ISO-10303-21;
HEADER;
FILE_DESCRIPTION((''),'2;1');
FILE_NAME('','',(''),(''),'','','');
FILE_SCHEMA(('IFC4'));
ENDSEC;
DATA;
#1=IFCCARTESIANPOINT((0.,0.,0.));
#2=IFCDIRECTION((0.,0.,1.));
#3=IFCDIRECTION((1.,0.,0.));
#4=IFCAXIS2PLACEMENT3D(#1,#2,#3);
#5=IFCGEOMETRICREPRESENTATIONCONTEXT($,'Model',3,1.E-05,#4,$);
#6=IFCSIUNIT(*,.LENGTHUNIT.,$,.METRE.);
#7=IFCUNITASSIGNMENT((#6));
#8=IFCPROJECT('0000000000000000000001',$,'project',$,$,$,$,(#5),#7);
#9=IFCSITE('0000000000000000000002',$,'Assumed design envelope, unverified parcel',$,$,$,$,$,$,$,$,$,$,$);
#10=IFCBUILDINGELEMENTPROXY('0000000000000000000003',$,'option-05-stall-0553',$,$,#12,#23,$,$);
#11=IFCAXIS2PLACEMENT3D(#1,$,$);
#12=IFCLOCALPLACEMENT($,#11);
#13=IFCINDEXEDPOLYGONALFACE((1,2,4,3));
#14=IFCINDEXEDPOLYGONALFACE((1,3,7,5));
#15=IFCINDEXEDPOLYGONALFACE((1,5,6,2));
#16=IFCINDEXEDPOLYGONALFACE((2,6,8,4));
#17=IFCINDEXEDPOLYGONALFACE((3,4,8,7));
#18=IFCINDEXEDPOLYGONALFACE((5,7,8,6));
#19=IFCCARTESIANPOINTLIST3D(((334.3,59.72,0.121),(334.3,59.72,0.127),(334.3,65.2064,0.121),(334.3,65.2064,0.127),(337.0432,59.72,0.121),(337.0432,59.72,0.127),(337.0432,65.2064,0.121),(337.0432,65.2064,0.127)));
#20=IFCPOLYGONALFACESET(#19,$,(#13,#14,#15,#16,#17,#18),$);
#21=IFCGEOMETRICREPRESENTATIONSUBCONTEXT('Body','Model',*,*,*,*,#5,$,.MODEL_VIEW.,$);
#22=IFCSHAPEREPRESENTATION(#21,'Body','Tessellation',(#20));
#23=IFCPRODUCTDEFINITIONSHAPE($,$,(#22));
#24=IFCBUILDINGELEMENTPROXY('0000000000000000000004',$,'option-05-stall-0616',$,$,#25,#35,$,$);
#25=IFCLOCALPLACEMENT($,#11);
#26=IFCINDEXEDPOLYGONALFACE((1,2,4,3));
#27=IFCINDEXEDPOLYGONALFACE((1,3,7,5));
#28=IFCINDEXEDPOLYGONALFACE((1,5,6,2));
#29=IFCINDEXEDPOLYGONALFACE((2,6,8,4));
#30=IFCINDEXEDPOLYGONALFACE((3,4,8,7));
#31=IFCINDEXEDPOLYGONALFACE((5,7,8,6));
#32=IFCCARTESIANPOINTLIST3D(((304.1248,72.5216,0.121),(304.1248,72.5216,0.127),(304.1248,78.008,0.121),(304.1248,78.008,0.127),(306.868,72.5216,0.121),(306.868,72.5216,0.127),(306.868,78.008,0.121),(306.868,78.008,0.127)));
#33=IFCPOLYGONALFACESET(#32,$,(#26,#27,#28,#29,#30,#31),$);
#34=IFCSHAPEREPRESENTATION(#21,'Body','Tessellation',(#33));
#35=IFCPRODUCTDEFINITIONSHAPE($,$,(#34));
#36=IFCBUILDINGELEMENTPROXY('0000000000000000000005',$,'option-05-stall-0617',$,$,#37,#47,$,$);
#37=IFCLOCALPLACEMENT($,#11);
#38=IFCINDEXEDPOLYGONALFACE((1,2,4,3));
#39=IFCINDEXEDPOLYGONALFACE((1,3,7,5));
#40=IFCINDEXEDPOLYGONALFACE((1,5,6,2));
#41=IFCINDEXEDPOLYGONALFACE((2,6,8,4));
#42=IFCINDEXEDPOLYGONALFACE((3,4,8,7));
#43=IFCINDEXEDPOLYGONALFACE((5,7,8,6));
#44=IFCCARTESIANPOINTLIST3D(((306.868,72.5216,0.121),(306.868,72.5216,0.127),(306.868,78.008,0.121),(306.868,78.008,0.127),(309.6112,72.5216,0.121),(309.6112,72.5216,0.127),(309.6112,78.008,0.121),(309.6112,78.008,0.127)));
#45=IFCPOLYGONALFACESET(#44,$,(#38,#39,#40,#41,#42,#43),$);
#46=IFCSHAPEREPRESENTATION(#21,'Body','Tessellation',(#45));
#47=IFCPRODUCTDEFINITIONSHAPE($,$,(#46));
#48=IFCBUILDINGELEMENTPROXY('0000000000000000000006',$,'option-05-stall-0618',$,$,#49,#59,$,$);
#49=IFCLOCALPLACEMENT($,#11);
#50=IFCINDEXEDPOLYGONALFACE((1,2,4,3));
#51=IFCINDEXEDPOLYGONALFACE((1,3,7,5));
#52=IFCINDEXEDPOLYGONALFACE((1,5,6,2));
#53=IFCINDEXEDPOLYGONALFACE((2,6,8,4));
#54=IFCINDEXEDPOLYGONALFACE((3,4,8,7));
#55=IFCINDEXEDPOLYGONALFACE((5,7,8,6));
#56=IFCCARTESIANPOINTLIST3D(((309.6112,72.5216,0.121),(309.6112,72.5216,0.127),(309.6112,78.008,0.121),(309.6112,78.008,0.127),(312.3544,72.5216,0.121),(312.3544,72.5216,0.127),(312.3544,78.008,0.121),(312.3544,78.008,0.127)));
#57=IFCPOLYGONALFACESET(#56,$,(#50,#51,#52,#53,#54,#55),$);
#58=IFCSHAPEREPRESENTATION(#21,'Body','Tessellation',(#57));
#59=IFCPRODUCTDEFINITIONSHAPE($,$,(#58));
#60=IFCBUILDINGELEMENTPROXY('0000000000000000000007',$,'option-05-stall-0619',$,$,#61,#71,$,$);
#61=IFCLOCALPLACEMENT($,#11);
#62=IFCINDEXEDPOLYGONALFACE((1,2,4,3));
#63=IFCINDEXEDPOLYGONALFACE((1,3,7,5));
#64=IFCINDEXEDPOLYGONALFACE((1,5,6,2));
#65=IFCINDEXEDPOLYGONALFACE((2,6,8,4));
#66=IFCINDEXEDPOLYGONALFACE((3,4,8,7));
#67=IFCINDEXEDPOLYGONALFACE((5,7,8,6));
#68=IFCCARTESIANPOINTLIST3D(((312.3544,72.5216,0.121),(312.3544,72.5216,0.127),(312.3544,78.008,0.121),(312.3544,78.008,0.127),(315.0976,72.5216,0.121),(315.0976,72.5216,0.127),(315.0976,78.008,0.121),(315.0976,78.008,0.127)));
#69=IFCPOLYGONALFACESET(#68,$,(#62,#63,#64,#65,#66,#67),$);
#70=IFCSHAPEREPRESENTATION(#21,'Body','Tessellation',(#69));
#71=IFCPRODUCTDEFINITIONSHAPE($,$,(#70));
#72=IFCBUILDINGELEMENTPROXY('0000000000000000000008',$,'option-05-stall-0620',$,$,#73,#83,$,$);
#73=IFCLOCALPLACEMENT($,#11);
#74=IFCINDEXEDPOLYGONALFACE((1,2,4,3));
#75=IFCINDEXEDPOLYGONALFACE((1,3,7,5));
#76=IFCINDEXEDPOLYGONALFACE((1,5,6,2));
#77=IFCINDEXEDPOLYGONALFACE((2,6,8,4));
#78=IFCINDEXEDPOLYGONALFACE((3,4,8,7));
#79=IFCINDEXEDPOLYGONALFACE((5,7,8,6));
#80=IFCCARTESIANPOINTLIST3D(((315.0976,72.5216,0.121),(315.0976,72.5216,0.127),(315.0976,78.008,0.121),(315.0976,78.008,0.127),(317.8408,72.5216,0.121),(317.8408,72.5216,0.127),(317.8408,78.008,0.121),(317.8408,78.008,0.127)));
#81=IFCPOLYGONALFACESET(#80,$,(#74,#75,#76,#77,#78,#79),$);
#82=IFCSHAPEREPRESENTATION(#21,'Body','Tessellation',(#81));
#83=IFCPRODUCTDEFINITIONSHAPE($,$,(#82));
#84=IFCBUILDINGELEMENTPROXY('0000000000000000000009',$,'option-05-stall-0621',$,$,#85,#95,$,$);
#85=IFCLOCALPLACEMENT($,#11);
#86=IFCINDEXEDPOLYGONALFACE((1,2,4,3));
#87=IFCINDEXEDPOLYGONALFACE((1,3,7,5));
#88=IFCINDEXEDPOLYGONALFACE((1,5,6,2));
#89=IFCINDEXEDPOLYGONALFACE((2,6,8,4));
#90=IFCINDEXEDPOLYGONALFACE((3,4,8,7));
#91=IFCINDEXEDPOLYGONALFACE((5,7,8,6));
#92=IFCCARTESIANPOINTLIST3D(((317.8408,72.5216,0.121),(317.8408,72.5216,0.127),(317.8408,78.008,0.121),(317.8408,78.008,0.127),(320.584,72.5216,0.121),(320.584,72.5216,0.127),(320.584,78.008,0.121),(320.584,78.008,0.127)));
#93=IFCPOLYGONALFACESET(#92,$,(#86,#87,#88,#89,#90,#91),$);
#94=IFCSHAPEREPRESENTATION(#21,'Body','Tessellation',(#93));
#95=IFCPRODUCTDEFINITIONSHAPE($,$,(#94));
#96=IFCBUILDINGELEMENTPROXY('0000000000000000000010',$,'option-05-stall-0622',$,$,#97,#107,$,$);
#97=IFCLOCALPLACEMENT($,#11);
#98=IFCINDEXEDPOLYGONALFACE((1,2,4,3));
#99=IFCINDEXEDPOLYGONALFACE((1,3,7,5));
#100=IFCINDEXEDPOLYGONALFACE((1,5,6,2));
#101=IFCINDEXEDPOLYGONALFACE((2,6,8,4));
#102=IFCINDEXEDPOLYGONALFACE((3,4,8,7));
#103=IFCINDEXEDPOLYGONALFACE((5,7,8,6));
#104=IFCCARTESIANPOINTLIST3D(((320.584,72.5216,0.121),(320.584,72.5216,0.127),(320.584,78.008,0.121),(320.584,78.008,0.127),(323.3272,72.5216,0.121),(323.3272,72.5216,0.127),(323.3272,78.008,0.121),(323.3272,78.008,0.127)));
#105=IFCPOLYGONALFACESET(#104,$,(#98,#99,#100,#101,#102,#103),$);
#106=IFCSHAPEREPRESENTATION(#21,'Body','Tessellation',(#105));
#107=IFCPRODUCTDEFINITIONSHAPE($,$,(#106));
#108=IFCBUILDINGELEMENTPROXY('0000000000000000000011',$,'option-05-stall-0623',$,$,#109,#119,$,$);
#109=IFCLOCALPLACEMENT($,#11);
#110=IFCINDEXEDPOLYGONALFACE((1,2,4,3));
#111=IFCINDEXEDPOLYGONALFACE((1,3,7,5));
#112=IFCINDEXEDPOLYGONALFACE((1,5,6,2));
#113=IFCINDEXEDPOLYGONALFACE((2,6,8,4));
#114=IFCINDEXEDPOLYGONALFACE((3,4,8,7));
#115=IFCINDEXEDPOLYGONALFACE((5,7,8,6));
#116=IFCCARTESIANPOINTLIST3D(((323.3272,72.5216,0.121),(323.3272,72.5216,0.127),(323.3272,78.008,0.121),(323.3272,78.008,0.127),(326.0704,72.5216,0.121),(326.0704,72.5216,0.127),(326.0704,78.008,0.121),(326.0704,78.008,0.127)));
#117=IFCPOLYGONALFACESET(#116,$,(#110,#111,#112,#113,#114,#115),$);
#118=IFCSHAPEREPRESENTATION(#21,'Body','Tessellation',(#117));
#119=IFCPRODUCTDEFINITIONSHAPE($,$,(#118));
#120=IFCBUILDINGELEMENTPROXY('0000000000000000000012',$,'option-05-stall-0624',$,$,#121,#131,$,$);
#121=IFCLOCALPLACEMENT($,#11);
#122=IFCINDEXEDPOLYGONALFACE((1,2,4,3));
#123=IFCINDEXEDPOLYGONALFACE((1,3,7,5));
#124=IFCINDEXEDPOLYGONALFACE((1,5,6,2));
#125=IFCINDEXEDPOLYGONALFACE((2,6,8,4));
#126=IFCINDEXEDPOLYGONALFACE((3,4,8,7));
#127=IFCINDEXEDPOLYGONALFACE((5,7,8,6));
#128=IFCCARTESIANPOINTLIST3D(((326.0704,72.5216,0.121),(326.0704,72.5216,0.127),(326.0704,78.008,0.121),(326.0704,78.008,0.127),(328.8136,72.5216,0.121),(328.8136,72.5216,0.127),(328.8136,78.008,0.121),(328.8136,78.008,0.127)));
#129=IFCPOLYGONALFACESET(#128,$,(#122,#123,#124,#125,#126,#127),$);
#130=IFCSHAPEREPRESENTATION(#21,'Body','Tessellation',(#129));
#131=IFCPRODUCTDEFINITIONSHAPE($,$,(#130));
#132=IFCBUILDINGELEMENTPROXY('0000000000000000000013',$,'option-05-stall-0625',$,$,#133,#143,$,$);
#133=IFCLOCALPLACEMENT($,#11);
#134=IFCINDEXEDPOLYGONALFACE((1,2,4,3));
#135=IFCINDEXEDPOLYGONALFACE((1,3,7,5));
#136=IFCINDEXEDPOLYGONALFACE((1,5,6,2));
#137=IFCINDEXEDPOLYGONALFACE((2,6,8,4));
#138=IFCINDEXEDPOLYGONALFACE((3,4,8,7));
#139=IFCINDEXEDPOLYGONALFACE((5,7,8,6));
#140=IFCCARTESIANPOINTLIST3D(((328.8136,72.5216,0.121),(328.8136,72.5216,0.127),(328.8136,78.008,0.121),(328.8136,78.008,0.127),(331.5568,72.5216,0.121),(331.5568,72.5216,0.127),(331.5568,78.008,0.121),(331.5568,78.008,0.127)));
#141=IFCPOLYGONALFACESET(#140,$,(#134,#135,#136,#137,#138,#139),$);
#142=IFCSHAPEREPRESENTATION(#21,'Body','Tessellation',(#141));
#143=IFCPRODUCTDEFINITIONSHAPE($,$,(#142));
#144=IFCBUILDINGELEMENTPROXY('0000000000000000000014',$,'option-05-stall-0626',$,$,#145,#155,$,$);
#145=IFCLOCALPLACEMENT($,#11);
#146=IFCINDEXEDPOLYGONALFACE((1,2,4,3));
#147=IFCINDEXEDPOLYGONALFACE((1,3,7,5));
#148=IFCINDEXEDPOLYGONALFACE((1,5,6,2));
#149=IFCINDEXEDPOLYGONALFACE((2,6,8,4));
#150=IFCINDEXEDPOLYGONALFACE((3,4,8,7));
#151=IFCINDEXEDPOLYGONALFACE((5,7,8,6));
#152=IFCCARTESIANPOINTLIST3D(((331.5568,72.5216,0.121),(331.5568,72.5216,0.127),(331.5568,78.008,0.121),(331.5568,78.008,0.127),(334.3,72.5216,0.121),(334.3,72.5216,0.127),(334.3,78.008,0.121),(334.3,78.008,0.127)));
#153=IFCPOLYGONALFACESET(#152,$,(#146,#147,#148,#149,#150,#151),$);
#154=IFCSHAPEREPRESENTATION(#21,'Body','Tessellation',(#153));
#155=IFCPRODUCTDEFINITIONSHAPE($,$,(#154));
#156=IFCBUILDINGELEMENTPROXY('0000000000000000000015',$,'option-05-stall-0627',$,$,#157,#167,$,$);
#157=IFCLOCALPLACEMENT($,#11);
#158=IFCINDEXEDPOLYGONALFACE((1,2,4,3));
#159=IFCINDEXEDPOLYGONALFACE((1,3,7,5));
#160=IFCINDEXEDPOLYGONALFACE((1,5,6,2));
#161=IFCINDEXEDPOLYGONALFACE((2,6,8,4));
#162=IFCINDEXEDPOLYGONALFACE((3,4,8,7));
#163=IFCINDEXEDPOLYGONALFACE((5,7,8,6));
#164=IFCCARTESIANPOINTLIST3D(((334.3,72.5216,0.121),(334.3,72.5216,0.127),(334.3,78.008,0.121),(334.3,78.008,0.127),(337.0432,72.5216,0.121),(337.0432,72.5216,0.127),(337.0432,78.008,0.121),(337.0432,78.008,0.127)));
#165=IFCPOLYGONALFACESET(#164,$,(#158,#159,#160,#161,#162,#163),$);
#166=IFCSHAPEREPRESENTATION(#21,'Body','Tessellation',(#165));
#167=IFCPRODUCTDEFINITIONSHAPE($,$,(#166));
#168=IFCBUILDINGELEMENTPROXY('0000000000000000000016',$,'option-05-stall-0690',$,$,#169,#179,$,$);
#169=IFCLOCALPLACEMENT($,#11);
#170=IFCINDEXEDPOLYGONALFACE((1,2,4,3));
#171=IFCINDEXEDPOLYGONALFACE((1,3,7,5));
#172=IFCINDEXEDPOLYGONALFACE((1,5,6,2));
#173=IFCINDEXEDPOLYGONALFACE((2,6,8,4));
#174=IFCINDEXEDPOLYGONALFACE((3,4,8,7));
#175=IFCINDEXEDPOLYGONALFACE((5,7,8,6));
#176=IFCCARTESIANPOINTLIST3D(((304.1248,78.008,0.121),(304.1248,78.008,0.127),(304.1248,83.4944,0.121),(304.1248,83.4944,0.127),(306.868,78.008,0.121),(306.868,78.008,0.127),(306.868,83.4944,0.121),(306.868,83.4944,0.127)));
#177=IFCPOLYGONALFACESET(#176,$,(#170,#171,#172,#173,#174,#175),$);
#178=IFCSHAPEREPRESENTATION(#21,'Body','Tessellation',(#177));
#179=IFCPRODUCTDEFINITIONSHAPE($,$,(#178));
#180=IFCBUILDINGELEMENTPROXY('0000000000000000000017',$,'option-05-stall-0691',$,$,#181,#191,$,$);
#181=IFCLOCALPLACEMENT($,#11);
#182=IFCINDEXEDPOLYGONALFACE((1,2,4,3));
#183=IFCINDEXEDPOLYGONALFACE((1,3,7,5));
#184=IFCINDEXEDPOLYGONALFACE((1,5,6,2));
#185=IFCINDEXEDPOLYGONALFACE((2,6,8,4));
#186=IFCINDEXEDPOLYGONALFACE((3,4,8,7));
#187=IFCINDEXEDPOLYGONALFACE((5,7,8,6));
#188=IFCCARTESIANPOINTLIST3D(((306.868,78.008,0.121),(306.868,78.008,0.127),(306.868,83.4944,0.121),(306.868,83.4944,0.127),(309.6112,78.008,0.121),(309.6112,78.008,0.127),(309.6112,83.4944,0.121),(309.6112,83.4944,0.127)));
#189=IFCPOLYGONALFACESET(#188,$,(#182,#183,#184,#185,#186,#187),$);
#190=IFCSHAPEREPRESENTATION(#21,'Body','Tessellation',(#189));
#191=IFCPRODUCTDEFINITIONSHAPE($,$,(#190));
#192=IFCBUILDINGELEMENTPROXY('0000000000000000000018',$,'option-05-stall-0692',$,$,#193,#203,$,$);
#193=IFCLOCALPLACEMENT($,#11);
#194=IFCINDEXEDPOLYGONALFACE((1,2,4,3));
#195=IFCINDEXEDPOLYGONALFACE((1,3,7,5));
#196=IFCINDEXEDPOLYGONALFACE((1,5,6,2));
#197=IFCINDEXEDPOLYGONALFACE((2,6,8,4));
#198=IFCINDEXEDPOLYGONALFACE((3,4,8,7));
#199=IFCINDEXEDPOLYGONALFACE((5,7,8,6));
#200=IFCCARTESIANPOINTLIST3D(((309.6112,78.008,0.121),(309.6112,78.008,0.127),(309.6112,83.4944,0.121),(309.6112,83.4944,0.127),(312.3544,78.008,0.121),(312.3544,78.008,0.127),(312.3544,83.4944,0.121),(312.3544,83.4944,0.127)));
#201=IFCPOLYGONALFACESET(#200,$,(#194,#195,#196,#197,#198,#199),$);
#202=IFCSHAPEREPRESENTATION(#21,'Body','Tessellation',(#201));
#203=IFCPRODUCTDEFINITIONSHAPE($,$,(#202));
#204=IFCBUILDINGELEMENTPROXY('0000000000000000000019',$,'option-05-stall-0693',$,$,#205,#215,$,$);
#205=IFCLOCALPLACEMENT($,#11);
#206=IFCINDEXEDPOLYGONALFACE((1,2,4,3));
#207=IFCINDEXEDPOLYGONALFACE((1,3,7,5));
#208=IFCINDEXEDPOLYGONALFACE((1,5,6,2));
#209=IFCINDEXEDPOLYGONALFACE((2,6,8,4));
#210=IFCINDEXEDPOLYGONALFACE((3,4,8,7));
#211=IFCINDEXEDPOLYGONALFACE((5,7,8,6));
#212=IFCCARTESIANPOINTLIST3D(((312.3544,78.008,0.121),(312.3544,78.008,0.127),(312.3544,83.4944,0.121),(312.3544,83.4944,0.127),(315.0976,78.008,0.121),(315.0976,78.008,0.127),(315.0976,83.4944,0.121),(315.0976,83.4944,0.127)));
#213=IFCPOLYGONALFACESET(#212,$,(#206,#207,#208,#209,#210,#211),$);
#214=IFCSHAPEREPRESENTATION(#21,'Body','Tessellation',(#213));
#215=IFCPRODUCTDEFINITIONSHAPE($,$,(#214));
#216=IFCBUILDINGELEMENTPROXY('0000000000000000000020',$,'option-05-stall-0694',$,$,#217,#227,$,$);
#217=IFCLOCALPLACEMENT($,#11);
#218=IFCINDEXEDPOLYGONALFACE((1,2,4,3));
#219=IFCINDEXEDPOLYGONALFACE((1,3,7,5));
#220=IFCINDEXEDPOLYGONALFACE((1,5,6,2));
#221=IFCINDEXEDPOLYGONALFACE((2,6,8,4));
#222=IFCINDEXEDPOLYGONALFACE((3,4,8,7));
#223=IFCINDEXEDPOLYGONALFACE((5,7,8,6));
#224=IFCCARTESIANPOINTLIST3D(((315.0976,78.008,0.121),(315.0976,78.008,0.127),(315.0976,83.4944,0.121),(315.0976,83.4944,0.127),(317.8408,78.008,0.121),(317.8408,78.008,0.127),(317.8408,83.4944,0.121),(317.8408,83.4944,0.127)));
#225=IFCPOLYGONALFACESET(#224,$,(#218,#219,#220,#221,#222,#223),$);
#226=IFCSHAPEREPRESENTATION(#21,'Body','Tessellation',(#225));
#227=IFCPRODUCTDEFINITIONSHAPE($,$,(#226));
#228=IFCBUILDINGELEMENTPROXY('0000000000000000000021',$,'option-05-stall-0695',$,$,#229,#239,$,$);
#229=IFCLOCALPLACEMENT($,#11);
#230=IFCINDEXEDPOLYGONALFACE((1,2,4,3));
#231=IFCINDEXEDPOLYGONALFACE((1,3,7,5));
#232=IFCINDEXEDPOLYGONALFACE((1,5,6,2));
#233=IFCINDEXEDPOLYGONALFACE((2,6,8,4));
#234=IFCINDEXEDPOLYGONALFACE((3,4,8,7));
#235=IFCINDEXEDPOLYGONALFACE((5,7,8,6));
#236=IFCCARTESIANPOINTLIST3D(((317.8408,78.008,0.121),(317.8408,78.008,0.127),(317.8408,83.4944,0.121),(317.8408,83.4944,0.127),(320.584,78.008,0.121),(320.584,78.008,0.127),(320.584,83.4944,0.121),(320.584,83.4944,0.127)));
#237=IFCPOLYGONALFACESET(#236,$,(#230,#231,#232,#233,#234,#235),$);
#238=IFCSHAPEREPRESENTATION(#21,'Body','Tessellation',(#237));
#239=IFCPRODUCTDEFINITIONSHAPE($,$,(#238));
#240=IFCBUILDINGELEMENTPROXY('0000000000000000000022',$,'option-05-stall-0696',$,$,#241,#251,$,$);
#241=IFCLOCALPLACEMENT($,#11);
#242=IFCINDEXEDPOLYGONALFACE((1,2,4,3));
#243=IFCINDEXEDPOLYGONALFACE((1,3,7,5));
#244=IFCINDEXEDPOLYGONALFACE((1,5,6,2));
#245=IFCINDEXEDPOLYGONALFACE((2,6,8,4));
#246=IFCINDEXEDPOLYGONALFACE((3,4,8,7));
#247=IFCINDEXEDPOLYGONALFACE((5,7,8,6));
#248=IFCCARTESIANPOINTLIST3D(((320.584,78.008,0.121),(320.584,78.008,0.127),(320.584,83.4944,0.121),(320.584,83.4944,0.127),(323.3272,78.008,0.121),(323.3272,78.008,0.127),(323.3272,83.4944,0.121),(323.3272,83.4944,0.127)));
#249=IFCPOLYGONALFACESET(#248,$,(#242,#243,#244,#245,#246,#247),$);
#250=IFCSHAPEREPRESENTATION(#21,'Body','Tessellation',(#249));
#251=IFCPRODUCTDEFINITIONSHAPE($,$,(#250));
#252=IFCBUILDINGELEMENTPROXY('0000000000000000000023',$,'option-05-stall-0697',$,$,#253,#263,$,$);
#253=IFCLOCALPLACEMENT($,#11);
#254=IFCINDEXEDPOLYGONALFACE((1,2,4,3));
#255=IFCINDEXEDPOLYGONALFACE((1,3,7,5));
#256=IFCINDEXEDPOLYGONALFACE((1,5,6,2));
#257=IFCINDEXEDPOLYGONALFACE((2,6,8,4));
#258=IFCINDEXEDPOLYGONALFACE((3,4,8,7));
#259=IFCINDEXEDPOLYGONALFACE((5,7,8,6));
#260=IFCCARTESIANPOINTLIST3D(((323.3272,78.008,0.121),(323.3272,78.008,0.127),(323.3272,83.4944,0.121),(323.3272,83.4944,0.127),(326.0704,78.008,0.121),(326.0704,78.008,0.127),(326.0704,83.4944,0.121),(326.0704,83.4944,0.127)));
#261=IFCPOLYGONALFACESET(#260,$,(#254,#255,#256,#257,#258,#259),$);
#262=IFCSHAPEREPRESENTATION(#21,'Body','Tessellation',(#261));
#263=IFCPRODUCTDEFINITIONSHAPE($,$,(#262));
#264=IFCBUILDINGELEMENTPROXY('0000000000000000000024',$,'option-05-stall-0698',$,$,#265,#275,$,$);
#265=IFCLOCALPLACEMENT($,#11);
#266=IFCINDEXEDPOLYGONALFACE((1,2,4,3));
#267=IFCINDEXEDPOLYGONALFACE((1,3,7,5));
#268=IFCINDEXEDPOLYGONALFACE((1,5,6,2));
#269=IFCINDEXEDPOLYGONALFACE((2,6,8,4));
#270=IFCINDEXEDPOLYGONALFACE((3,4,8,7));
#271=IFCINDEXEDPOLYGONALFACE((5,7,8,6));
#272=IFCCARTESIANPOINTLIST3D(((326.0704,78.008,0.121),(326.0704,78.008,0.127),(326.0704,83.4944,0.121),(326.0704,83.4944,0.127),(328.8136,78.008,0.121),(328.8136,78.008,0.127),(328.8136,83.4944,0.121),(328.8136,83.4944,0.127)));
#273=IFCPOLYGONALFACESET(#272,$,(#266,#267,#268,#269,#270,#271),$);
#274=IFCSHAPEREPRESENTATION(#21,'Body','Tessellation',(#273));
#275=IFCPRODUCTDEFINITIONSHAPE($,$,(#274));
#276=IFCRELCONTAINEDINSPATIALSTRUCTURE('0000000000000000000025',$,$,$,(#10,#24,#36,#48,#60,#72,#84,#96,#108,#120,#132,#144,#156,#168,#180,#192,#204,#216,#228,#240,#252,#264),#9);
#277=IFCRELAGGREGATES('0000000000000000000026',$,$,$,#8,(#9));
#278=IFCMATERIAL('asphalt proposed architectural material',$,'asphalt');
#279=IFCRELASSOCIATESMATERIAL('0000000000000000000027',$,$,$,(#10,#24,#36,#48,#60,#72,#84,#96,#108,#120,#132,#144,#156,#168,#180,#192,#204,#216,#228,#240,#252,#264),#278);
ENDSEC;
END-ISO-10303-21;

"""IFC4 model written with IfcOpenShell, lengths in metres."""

from ifc_helpers import new_model, si_unit, frame, origin_with_axes, place, context, subcontext, project, spatial, rectangle, extrude, material, element, save


model = new_model("IFC4")

# Units and contexts
model_context = context("Model", 3, precision=1e-05, world=origin_with_axes())
body_context = subcontext(model_context, "Body", "Model", "MODEL_VIEW")
ifc_project = project(units=[si_unit("LENGTHUNIT", "METRE")], contexts=[model_context])

# Site
site = spatial("IfcSite", under=ifc_project, Name="Assumed design envelope, unverified parcel")

# Building element proxies
ifc_material = material(Name="asphalt proposed architectural material", Category="asphalt")
for number, where, z_axis, x_axis, name in (
    (1, (335.6716, 62.4632, 0.121), (0.0, 0.0, 1.0), (1.0, 0.0, 0.0), "option-05-stall-0553"),
    (2, (305.4964, 75.2648, 0.121), (0.0, 0.0, 1.0), (1.0, 0.0, 0.0), "option-05-stall-0616"),
    (3, (308.2396, 75.2648, 0.121), (0.0, 0.0, 1.0), (1.0, 0.0, 0.0), "option-05-stall-0617"),
    (4, (310.9828, 75.2648, 0.121), (0.0, 0.0, 1.0), (1.0, 0.0, 0.0), "option-05-stall-0618"),
    (5, (313.726, 75.2648, 0.121), (0.0, 0.0, 1.0), (1.0, 0.0, 0.0), "option-05-stall-0619"),
    (6, (316.4692, 75.2648, 0.121), (0.0, 0.0, 1.0), (1.0, 0.0, 0.0), "option-05-stall-0620"),
    (7, (319.2124, 75.2648, 0.121), (0.0, 0.0, 1.0), (1.0, 0.0, 0.0), "option-05-stall-0621"),
    (8, (321.9556, 75.2648, 0.121), (0.0, 0.0, 1.0), (1.0, 0.0, 0.0), "option-05-stall-0622"),
    (9, (324.6988, 75.2648, 0.121), (0.0, 0.0, 1.0), (1.0, 0.0, 0.0), "option-05-stall-0623"),
    (10, (327.442, 75.2648, 0.121), (0.0, 0.0, 1.0), (1.0, 0.0, 0.0), "option-05-stall-0624"),
    (11, (330.1852, 75.2648, 0.121), (0.0, 0.0, 1.0), (1.0, 0.0, 0.0), "option-05-stall-0625"),
    (12, (332.9284, 75.2648, 0.121), (0.0, 0.0, 1.0), (1.0, 0.0, 0.0), "option-05-stall-0626"),
    (13, (335.6716, 75.2648, 0.121), (0.0, 0.0, 1.0), (1.0, 0.0, 0.0), "option-05-stall-0627"),
    (14, (305.4964, 80.7512, 0.121), (0.0, 0.0, 1.0), (1.0, 0.0, 0.0), "option-05-stall-0690"),
    (15, (308.2396, 80.7512, 0.121), (0.0, 0.0, 1.0), (1.0, 0.0, 0.0), "option-05-stall-0691"),
    (16, (310.9828, 80.7512, 0.121), (0.0, 0.0, 1.0), (1.0, 0.0, 0.0), "option-05-stall-0692"),
    (17, (313.726, 80.7512, 0.121), (0.0, 0.0, 1.0), (1.0, 0.0, 0.0), "option-05-stall-0693"),
    (18, (316.4692, 80.7512, 0.121), (0.0, 0.0, 1.0), (1.0, 0.0, 0.0), "option-05-stall-0694"),
    (19, (319.2124, 80.7512, 0.121), (0.0, 0.0, 1.0), (1.0, 0.0, 0.0), "option-05-stall-0695"),
    (20, (321.9556, 80.7512, 0.121), (0.0, 0.0, 1.0), (1.0, 0.0, 0.0), "option-05-stall-0696"),
    (21, (324.6988, 80.7512, 0.121), (0.0, 0.0, 1.0), (1.0, 0.0, 0.0), "option-05-stall-0697"),
    (22, (327.442, 80.7512, 0.121), (0.0, 0.0, 1.0), (1.0, 0.0, 0.0), "option-05-stall-0698"),
):
    element("IfcBuildingElementProxy", number, at=place(None, frame(where, z_axis=z_axis, x_axis=x_axis)), inside=site, material=ifc_material, Name=name, context=body_context, shape_type="SweptSolid", body=[
        extrude(rectangle(XDim=2.7432, YDim=5.4864), origin_with_axes(), (0.0, 0.0, 1.0), 0.006),
    ])

save(model, "model.ifc")
